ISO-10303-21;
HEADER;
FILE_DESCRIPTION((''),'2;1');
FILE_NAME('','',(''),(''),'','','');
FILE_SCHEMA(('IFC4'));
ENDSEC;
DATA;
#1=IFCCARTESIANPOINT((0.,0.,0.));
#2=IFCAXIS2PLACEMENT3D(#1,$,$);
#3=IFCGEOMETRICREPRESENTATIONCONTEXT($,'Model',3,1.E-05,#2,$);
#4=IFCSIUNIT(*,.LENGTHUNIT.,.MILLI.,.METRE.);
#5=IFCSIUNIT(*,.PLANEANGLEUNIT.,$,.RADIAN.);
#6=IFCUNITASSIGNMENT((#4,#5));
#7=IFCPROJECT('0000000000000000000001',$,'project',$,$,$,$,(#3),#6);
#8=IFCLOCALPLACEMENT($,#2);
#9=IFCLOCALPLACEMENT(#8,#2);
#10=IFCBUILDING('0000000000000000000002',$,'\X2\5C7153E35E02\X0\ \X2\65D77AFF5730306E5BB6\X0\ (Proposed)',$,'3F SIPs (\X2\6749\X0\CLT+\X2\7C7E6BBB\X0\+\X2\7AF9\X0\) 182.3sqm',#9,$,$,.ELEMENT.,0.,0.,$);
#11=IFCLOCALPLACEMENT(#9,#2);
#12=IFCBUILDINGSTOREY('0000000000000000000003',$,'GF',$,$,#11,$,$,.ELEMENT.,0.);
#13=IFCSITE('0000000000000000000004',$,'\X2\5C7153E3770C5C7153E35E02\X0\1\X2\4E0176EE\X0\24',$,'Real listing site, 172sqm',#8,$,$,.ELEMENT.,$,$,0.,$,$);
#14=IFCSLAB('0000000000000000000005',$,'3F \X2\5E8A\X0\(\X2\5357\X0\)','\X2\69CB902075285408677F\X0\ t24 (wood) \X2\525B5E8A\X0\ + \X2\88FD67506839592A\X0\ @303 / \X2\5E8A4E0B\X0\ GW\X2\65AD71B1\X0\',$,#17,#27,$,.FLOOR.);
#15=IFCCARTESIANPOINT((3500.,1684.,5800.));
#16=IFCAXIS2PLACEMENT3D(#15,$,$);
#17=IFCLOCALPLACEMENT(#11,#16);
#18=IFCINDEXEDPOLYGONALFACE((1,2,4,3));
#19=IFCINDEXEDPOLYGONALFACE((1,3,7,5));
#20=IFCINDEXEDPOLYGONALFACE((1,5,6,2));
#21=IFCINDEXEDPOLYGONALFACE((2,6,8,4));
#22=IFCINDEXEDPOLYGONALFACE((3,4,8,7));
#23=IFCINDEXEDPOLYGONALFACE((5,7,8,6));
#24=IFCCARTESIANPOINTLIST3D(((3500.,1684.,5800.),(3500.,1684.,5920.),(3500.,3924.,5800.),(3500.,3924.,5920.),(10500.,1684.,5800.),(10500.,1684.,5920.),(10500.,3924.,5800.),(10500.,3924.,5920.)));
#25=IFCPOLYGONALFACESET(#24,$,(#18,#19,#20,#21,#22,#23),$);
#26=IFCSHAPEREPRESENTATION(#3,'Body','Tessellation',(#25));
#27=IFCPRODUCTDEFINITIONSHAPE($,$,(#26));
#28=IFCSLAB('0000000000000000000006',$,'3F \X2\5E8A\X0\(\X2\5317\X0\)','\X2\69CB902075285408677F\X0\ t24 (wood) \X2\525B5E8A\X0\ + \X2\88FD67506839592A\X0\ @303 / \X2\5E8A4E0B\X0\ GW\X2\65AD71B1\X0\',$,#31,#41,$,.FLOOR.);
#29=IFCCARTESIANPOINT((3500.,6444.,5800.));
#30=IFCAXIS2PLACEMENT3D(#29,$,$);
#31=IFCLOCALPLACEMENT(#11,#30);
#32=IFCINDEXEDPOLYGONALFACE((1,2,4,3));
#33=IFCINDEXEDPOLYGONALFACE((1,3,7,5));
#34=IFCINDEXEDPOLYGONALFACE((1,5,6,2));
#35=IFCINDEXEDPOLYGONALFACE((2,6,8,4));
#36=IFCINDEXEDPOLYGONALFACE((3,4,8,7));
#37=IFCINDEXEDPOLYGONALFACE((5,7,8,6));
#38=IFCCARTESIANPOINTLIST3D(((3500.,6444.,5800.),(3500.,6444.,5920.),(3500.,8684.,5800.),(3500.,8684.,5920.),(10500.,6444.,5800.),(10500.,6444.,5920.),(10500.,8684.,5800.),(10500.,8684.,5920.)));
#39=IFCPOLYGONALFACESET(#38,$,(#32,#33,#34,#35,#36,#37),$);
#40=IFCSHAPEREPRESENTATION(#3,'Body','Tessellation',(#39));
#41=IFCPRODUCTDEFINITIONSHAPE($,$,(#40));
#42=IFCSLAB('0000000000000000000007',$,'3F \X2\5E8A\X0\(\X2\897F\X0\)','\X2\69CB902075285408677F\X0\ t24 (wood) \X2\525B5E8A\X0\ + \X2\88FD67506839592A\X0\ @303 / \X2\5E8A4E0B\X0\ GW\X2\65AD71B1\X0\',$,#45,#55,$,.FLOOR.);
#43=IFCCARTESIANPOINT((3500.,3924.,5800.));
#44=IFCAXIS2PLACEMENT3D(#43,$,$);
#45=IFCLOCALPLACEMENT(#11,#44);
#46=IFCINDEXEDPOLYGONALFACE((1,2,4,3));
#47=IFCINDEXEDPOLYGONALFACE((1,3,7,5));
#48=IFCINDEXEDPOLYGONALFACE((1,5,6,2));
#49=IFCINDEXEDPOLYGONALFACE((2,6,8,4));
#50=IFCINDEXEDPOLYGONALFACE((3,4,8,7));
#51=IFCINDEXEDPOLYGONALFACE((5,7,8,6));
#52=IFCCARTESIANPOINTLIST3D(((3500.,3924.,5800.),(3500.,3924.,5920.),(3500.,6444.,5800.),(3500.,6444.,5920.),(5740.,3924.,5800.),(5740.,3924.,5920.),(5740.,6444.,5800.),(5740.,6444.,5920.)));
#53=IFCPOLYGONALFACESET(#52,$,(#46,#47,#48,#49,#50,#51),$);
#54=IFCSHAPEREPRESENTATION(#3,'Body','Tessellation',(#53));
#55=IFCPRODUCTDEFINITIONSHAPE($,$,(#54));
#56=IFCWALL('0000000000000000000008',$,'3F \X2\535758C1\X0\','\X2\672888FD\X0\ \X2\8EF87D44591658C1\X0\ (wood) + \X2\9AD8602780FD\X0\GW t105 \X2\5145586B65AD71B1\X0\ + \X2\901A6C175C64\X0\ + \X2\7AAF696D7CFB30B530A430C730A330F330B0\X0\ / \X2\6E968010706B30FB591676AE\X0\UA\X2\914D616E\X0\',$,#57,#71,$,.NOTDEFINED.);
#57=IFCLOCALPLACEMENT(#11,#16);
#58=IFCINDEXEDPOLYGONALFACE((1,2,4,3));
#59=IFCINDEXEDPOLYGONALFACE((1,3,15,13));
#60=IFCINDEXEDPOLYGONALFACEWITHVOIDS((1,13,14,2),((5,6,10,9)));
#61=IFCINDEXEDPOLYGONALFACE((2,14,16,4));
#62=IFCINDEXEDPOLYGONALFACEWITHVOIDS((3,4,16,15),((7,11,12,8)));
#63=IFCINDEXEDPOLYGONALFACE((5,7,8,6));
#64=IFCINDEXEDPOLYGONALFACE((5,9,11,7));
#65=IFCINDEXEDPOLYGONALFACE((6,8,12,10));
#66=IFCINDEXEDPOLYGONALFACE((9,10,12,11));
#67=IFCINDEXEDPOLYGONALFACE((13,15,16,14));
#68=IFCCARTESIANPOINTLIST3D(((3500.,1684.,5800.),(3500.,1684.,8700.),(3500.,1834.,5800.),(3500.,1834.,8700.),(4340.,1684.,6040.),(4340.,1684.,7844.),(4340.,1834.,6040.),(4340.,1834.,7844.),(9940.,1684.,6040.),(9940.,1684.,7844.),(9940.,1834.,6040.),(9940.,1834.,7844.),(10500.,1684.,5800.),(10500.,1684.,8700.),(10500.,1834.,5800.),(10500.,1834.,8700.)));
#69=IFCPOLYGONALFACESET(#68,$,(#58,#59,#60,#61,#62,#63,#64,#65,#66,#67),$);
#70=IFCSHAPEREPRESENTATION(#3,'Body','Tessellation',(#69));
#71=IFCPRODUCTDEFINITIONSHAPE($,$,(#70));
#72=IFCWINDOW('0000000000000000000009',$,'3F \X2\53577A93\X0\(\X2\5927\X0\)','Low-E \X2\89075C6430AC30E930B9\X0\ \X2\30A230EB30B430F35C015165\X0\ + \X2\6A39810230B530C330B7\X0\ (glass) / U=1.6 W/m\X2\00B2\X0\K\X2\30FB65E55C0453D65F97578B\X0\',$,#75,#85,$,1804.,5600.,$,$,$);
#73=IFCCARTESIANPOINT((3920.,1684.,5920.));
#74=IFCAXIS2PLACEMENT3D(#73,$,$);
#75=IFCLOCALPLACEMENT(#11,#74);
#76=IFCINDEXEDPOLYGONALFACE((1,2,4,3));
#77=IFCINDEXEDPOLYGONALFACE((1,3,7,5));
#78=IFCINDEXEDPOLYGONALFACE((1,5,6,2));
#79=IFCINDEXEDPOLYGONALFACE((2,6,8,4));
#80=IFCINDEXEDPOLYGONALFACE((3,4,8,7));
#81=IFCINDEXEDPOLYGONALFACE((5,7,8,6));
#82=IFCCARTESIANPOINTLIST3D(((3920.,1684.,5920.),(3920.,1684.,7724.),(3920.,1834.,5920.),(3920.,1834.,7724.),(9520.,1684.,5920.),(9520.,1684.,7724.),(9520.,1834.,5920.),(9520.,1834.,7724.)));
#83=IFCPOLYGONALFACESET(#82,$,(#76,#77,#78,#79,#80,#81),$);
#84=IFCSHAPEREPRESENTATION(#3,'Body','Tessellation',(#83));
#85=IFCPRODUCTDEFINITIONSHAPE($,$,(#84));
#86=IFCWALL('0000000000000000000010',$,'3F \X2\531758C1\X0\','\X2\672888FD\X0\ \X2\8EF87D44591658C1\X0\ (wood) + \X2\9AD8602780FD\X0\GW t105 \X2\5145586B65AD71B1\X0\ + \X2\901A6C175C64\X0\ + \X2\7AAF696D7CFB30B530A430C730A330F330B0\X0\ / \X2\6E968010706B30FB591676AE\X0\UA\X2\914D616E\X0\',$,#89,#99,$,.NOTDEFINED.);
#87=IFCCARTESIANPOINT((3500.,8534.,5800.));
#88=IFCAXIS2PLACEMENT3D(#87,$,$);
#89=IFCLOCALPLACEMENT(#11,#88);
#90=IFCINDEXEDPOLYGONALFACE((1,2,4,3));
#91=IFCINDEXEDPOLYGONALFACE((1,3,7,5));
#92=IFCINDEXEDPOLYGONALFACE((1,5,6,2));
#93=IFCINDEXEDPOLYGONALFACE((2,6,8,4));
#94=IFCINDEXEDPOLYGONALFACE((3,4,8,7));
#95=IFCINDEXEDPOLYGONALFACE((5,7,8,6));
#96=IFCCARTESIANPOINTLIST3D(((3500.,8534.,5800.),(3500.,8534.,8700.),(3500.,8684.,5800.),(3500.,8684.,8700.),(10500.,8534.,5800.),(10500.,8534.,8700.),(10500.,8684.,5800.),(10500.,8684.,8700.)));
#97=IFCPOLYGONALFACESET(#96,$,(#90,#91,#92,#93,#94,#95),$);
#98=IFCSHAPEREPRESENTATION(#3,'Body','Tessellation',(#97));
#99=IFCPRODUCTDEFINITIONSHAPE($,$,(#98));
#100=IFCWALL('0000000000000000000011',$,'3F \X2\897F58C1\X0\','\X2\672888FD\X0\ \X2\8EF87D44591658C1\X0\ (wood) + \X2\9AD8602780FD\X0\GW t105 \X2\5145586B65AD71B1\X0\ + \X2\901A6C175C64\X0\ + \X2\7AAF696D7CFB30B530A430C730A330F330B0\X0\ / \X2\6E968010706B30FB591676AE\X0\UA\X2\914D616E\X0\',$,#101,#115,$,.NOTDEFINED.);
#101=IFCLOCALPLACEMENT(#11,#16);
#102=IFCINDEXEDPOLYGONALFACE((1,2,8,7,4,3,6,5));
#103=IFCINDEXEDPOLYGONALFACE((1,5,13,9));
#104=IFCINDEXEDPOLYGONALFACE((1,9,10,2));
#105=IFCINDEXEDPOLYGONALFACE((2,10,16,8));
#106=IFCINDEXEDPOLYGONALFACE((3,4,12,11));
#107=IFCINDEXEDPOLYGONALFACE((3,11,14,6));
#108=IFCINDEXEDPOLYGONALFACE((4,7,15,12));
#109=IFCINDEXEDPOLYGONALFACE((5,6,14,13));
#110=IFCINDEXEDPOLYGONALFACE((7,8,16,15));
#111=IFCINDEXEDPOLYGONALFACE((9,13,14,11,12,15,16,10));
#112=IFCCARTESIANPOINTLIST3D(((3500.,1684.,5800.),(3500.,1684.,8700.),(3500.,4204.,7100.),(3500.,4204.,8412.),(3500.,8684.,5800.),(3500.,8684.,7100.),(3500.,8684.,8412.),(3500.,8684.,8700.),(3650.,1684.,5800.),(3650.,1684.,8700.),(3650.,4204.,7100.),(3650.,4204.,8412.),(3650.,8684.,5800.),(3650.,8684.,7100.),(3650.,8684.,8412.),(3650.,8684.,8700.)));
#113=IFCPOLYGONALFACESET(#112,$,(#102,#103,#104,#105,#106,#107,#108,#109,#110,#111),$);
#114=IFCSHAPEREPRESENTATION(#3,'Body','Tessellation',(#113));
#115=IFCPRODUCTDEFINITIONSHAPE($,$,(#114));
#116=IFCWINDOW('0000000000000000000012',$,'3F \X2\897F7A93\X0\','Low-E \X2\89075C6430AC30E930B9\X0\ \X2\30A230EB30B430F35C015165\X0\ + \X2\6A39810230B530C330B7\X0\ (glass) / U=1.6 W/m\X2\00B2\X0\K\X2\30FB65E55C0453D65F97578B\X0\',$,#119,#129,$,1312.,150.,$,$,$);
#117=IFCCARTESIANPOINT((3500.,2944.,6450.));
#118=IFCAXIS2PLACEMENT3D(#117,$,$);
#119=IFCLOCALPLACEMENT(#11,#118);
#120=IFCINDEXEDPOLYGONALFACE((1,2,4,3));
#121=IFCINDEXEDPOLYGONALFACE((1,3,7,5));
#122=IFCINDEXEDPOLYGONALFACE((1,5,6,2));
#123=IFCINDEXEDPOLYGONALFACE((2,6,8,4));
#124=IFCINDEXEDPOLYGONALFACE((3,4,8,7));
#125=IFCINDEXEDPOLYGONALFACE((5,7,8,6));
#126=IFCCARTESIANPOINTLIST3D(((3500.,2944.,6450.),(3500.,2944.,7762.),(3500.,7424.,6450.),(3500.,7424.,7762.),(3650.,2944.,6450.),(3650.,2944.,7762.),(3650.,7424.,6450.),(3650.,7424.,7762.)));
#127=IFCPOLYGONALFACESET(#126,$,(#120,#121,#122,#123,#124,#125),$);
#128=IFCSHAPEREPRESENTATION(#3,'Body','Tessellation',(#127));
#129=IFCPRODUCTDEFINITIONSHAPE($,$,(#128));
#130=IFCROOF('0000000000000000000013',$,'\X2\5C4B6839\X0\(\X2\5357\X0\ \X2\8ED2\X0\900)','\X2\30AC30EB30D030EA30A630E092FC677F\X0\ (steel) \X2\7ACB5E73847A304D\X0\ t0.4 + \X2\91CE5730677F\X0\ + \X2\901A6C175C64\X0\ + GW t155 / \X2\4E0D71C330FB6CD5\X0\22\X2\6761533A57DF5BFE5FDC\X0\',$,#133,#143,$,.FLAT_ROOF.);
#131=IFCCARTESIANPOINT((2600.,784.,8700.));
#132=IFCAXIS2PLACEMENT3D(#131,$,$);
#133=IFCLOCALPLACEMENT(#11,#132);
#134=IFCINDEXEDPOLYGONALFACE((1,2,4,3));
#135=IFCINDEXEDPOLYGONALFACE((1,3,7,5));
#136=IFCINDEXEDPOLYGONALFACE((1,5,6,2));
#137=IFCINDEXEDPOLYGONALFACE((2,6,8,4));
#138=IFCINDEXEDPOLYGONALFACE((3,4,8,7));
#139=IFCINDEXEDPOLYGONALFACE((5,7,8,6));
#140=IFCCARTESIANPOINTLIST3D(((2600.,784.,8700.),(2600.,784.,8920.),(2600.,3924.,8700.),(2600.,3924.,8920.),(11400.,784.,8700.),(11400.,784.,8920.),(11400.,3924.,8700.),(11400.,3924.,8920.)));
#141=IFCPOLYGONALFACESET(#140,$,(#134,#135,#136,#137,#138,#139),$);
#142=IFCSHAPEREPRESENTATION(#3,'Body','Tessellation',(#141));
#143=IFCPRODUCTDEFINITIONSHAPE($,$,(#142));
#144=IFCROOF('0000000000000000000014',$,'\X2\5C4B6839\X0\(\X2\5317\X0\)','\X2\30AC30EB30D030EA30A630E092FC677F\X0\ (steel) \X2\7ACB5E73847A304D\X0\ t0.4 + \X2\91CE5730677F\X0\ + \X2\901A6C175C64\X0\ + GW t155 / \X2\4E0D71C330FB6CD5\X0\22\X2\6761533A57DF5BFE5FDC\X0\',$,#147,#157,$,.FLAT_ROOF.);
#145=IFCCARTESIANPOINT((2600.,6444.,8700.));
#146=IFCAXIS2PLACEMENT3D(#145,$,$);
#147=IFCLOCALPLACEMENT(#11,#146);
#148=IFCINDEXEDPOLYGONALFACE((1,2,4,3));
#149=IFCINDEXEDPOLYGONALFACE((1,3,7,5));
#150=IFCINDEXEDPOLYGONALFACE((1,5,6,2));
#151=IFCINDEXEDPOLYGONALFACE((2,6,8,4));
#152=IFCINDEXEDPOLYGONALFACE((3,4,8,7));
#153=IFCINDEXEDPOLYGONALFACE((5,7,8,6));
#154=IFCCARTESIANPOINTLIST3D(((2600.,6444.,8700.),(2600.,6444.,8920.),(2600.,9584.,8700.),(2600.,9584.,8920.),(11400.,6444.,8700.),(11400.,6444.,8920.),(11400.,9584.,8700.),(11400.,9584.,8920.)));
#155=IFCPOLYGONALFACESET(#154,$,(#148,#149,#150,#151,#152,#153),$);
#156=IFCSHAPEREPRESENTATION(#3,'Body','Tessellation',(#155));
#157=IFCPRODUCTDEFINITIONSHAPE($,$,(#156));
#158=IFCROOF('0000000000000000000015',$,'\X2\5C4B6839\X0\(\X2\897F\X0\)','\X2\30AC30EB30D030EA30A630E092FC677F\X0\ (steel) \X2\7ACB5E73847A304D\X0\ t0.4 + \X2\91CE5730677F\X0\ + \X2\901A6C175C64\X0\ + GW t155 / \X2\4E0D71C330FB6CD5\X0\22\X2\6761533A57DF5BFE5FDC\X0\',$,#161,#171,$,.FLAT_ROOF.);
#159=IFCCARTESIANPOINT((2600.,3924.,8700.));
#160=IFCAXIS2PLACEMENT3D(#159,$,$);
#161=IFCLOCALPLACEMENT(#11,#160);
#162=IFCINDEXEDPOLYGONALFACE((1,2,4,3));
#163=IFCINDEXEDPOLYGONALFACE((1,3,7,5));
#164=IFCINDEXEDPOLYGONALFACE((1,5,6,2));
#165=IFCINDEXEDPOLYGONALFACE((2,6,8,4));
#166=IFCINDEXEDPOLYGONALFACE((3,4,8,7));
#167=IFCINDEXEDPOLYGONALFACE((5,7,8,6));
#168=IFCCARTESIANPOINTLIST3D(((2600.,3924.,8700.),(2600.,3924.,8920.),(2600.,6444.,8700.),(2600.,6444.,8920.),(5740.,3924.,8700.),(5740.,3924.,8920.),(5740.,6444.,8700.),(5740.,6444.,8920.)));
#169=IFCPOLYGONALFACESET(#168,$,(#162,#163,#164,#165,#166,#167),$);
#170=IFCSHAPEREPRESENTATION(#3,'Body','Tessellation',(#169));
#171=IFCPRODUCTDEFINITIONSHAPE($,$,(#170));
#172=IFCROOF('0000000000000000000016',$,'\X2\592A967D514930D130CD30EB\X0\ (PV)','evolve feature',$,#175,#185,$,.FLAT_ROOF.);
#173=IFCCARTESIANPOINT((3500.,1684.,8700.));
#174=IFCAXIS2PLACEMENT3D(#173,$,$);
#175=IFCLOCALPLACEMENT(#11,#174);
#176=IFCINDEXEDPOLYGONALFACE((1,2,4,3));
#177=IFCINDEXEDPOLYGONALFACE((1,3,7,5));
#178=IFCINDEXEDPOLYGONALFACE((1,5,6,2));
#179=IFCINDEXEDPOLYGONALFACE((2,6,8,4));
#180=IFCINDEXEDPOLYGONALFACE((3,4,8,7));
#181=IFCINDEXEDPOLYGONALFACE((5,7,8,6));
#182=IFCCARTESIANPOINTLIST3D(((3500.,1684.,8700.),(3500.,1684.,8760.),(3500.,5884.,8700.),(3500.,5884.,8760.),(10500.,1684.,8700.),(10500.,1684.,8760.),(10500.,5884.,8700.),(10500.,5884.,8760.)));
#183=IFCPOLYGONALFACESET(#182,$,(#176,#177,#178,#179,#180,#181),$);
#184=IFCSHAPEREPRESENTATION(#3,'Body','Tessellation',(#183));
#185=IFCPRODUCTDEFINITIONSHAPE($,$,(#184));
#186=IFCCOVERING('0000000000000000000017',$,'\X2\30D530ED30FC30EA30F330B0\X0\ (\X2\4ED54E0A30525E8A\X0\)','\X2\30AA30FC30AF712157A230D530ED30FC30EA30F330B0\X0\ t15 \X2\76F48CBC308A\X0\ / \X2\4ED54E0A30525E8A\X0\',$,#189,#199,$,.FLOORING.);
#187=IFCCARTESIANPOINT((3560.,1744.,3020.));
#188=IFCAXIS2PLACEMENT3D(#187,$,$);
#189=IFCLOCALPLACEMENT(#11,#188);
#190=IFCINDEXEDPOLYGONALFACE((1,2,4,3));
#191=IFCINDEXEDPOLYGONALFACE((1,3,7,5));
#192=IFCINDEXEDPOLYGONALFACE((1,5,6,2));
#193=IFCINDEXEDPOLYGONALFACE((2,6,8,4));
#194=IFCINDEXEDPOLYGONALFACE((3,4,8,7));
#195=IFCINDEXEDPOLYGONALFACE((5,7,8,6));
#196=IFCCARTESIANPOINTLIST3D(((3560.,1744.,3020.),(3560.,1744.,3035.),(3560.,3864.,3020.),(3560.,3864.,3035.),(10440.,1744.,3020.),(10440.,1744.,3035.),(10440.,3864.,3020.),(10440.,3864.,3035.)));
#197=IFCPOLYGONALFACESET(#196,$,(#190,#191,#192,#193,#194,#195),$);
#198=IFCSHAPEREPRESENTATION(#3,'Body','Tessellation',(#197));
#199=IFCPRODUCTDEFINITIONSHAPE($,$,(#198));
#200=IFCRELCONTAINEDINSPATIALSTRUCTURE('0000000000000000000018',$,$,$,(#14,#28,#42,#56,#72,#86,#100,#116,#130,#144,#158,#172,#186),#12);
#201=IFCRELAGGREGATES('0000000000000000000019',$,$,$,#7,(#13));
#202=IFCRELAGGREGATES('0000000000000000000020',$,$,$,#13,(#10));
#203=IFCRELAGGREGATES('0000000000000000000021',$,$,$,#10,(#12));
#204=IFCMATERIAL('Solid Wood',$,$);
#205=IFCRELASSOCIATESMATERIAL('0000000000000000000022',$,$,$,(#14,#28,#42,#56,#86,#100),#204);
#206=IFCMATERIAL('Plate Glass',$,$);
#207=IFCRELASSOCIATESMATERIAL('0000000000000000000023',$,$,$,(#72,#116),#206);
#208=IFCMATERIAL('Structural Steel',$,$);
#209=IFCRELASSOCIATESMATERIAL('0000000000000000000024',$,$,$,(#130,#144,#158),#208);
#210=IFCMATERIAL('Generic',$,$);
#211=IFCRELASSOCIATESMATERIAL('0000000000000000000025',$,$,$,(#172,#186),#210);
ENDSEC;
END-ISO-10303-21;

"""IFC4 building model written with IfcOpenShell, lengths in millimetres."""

from ifc_helpers import new_model, si_unit, frame, frame_2d, origin, place, context, project, spatial, rectangle, extrude, material, element, fill, save


model = new_model("IFC4")

# Units and contexts
model_context = context("Model", 3, precision=1e-05, world=origin())
ifc_project = project(units=[si_unit("LENGTHUNIT", "METRE", prefix="MILLI"), si_unit("PLANEANGLEUNIT", "RADIAN")], contexts=[model_context])

# Site, building, storey
site_placement = place(None, origin())
site = spatial("IfcSite", under=ifc_project, at=site_placement, Name="山口県山口市1丁目24", ObjectType="Real listing site, 172sqm", CompositionType="ELEMENT", RefElevation=0.0)
building_placement = place(site_placement, origin())
building = spatial("IfcBuilding", under=site, at=building_placement, Name="山口市 旗竿地の家 (Proposed)", ObjectType="3F SIPs (杉CLT+籾殻+竹) 182.3sqm", CompositionType="ELEMENT", ElevationOfRefHeight=0.0, ElevationOfTerrain=0.0)
storey_placement = place(building_placement, origin())
storey = spatial("IfcBuildingStorey", under=building, at=storey_placement, Name="GF", CompositionType="ELEMENT", Elevation=0.0)

# Slabs
ifc_material_1 = material(Name="Solid Wood")
slab_1_placement = place(storey_placement, frame((3500.0, 1684.0, 5800.0)))
element("IfcSlab", 1, at=slab_1_placement, inside=storey, material=ifc_material_1, Name="3F 床(南)", Description="構造用合板 t24 (wood) 剛床 + 製材根太 @303 / 床下 GW断熱", PredefinedType="FLOOR", context=model_context, shape_type="SweptSolid", body=[
    extrude(rectangle(XDim=7000.0, YDim=2240.0, at=frame_2d((3500.0, 1120.0))), frame((3500.0, 1684.0, 5800.0)), (0.0, 0.0, 1.0), 120.0),
])
slab_2_placement = place(storey_placement, frame((3500.0, 6444.0, 5800.0)))
element("IfcSlab", 2, at=slab_2_placement, inside=storey, material=ifc_material_1, Name="3F 床(北)", Description="構造用合板 t24 (wood) 剛床 + 製材根太 @303 / 床下 GW断熱", PredefinedType="FLOOR", context=model_context, shape_type="SweptSolid", body=[
    extrude(rectangle(XDim=7000.0, YDim=2240.0, at=frame_2d((3500.0, 1120.0))), frame((3500.0, 6444.0, 5800.0)), (0.0, 0.0, 1.0), 120.0),
])
slab_3_placement = place(storey_placement, frame((3500.0, 3924.0, 5800.0)))
element("IfcSlab", 3, at=slab_3_placement, inside=storey, material=ifc_material_1, Name="3F 床(西)", Description="構造用合板 t24 (wood) 剛床 + 製材根太 @303 / 床下 GW断熱", PredefinedType="FLOOR", context=model_context, shape_type="SweptSolid", body=[
    extrude(rectangle(XDim=2240.0, YDim=2520.0, at=frame_2d((1120.0, 1260.0))), frame((3500.0, 3924.0, 5800.0)), (0.0, 0.0, 1.0), 120.0),
])

# Wall, opening, window
wall_1_placement = place(storey_placement, frame((3500.0, 1684.0, 5800.0)))
wall_1 = element("IfcWall", 4, at=wall_1_placement, inside=storey, material=ifc_material_1, Name="3F 南壁", Description="木製 軸組外壁 (wood) + 高性能GW t105 充填断熱 + 通気層 + 窯業系サイディング / 準耐火・外皮UA配慮", PredefinedType="NOTDEFINED", context=model_context, shape_type="SweptSolid", body=[
    extrude(rectangle(XDim=7000.0, YDim=150.0, at=frame_2d((3500.0, 75.0))), frame((3500.0, 1684.0, 5800.0)), (0.0, 0.0, 1.0), 2900.0),
])
opening_1_placement = place(storey_placement, frame((3920.0, 1684.0, 5920.0)))
opening_1 = element("IfcOpeningElement", 5, at=opening_1_placement, cuts=wall_1, PredefinedType="NOTDEFINED", context=model_context, shape_type="SweptSolid", body=[
    extrude(rectangle(XDim=5600.0, YDim=150.0, at=frame_2d((2800.0, 75.0))), frame((3920.0, 1684.0, 5920.0)), (0.0, 0.0, 1.0), 1804.0),
])
ifc_material_2 = material(Name="Plate Glass")
window_1_placement = place(storey_placement, frame((3920.0, 1684.0, 5920.0)))
window_1 = element("IfcWindow", 6, at=window_1_placement, inside=storey, material=ifc_material_2, Name="3F 南窓(大)", Description="Low-E 複層ガラス アルゴン封入 + 樹脂サッシ (glass) / U=1.6 W/m²K・日射取得型", OverallHeight=1804.0, OverallWidth=5600.0, context=model_context, shape_type="SweptSolid", body=[
    extrude(rectangle(XDim=5600.0, YDim=150.0, at=frame_2d((2800.0, 75.0))), frame((3920.0, 1684.0, 5920.0)), (0.0, 0.0, 1.0), 1804.0),
])
fill(opening_1, window_1)

# Wall
wall_2_placement = place(storey_placement, frame((3500.0, 8534.0, 5800.0)))
element("IfcWall", 7, at=wall_2_placement, inside=storey, material=ifc_material_1, Name="3F 北壁", Description="木製 軸組外壁 (wood) + 高性能GW t105 充填断熱 + 通気層 + 窯業系サイディング / 準耐火・外皮UA配慮", PredefinedType="NOTDEFINED", context=model_context, shape_type="SweptSolid", body=[
    extrude(rectangle(XDim=7000.0, YDim=150.0, at=frame_2d((3500.0, 75.0))), frame((3500.0, 8534.0, 5800.0)), (0.0, 0.0, 1.0), 2900.0),
])

# Wall, opening, window
wall_3_placement = place(storey_placement, frame((3500.0, 1684.0, 5800.0)))
wall_3 = element("IfcWall", 8, at=wall_3_placement, inside=storey, material=ifc_material_1, Name="3F 西壁", Description="木製 軸組外壁 (wood) + 高性能GW t105 充填断熱 + 通気層 + 窯業系サイディング / 準耐火・外皮UA配慮", PredefinedType="NOTDEFINED", context=model_context, shape_type="SweptSolid", body=[
    extrude(rectangle(XDim=150.0, YDim=7000.0, at=frame_2d((75.0, 3500.0))), frame((3500.0, 1684.0, 5800.0)), (0.0, 0.0, 1.0), 2900.0),
])
opening_2_placement = place(storey_placement, frame((3500.0, 2944.0, 6450.0)))
opening_2 = element("IfcOpeningElement", 9, at=opening_2_placement, cuts=wall_3, PredefinedType="NOTDEFINED", context=model_context, shape_type="SweptSolid", body=[
    extrude(rectangle(XDim=150.0, YDim=4480.0, at=frame_2d((75.0, 2240.0))), frame((3500.0, 2944.0, 6450.0)), (0.0, 0.0, 1.0), 1312.0),
])
window_2_placement = place(storey_placement, frame((3500.0, 2944.0, 6450.0)))
window_2 = element("IfcWindow", 10, at=window_2_placement, inside=storey, material=ifc_material_2, Name="3F 西窓", Description="Low-E 複層ガラス アルゴン封入 + 樹脂サッシ (glass) / U=1.6 W/m²K・日射取得型", OverallHeight=1312.0, OverallWidth=150.0, context=model_context, shape_type="SweptSolid", body=[
    extrude(rectangle(XDim=150.0, YDim=4480.0, at=frame_2d((75.0, 2240.0))), frame((3500.0, 2944.0, 6450.0)), (0.0, 0.0, 1.0), 1312.0),
])
fill(opening_2, window_2)

# Roofs
ifc_material_3 = material(Name="Structural Steel")
roof_1_placement = place(storey_placement, frame((2600.0, 784.0, 8700.0)))
element("IfcRoof", 11, at=roof_1_placement, inside=storey, material=ifc_material_3, Name="屋根(南 軒900)", Description="ガルバリウム鋼板 (steel) 立平葺き t0.4 + 野地板 + 通気層 + GW t155 / 不燃・法22条区域対応", PredefinedType="FLAT_ROOF", context=model_context, shape_type="SweptSolid", body=[
    extrude(rectangle(XDim=8800.0, YDim=3140.0, at=frame_2d((4400.0, 1570.0))), frame((2600.0, 784.0, 8700.0)), (0.0, 0.0, 1.0), 220.0),
])
roof_2_placement = place(storey_placement, frame((2600.0, 6444.0, 8700.0)))
element("IfcRoof", 12, at=roof_2_placement, inside=storey, material=ifc_material_3, Name="屋根(北)", Description="ガルバリウム鋼板 (steel) 立平葺き t0.4 + 野地板 + 通気層 + GW t155 / 不燃・法22条区域対応", PredefinedType="FLAT_ROOF", context=model_context, shape_type="SweptSolid", body=[
    extrude(rectangle(XDim=8800.0, YDim=3140.0, at=frame_2d((4400.0, 1570.0))), frame((2600.0, 6444.0, 8700.0)), (0.0, 0.0, 1.0), 220.0),
])
roof_3_placement = place(storey_placement, frame((2600.0, 3924.0, 8700.0)))
element("IfcRoof", 13, at=roof_3_placement, inside=storey, material=ifc_material_3, Name="屋根(西)", Description="ガルバリウム鋼板 (steel) 立平葺き t0.4 + 野地板 + 通気層 + GW t155 / 不燃・法22条区域対応", PredefinedType="FLAT_ROOF", context=model_context, shape_type="SweptSolid", body=[
    extrude(rectangle(XDim=3140.0, YDim=2520.0, at=frame_2d((1570.0, 1260.0))), frame((2600.0, 3924.0, 8700.0)), (0.0, 0.0, 1.0), 220.0),
])
ifc_material_4 = material(Name="Generic")
roof_4_placement = place(storey_placement, frame((3500.0, 1684.0, 8700.0)))
element("IfcRoof", 14, at=roof_4_placement, inside=storey, material=ifc_material_4, Name="太陽光パネル (PV)", Description="evolve feature", PredefinedType="FLAT_ROOF", context=model_context, shape_type="SweptSolid", body=[
    extrude(rectangle(XDim=7000.0, YDim=4200.0, at=frame_2d((3500.0, 2100.0))), frame((3500.0, 1684.0, 8700.0)), (0.0, 0.0, 1.0), 60.0),
])

# Covering
covering_1_placement = place(storey_placement, frame((3560.0, 1744.0, 3020.0)))
element("IfcCovering", 15, at=covering_1_placement, inside=storey, material=ifc_material_4, Name="フローリング (仕上げ床)", Description="オーク無垢フローリング t15 直貼り / 仕上げ床", PredefinedType="FLOORING", context=model_context, shape_type="SweptSolid", body=[
    extrude(rectangle(XDim=6880.0, YDim=2120.0, at=frame_2d((3440.0, 1060.0))), frame((3560.0, 1744.0, 3020.0)), (0.0, 0.0, 1.0), 15.0),
])

save(model, "model.ifc")
